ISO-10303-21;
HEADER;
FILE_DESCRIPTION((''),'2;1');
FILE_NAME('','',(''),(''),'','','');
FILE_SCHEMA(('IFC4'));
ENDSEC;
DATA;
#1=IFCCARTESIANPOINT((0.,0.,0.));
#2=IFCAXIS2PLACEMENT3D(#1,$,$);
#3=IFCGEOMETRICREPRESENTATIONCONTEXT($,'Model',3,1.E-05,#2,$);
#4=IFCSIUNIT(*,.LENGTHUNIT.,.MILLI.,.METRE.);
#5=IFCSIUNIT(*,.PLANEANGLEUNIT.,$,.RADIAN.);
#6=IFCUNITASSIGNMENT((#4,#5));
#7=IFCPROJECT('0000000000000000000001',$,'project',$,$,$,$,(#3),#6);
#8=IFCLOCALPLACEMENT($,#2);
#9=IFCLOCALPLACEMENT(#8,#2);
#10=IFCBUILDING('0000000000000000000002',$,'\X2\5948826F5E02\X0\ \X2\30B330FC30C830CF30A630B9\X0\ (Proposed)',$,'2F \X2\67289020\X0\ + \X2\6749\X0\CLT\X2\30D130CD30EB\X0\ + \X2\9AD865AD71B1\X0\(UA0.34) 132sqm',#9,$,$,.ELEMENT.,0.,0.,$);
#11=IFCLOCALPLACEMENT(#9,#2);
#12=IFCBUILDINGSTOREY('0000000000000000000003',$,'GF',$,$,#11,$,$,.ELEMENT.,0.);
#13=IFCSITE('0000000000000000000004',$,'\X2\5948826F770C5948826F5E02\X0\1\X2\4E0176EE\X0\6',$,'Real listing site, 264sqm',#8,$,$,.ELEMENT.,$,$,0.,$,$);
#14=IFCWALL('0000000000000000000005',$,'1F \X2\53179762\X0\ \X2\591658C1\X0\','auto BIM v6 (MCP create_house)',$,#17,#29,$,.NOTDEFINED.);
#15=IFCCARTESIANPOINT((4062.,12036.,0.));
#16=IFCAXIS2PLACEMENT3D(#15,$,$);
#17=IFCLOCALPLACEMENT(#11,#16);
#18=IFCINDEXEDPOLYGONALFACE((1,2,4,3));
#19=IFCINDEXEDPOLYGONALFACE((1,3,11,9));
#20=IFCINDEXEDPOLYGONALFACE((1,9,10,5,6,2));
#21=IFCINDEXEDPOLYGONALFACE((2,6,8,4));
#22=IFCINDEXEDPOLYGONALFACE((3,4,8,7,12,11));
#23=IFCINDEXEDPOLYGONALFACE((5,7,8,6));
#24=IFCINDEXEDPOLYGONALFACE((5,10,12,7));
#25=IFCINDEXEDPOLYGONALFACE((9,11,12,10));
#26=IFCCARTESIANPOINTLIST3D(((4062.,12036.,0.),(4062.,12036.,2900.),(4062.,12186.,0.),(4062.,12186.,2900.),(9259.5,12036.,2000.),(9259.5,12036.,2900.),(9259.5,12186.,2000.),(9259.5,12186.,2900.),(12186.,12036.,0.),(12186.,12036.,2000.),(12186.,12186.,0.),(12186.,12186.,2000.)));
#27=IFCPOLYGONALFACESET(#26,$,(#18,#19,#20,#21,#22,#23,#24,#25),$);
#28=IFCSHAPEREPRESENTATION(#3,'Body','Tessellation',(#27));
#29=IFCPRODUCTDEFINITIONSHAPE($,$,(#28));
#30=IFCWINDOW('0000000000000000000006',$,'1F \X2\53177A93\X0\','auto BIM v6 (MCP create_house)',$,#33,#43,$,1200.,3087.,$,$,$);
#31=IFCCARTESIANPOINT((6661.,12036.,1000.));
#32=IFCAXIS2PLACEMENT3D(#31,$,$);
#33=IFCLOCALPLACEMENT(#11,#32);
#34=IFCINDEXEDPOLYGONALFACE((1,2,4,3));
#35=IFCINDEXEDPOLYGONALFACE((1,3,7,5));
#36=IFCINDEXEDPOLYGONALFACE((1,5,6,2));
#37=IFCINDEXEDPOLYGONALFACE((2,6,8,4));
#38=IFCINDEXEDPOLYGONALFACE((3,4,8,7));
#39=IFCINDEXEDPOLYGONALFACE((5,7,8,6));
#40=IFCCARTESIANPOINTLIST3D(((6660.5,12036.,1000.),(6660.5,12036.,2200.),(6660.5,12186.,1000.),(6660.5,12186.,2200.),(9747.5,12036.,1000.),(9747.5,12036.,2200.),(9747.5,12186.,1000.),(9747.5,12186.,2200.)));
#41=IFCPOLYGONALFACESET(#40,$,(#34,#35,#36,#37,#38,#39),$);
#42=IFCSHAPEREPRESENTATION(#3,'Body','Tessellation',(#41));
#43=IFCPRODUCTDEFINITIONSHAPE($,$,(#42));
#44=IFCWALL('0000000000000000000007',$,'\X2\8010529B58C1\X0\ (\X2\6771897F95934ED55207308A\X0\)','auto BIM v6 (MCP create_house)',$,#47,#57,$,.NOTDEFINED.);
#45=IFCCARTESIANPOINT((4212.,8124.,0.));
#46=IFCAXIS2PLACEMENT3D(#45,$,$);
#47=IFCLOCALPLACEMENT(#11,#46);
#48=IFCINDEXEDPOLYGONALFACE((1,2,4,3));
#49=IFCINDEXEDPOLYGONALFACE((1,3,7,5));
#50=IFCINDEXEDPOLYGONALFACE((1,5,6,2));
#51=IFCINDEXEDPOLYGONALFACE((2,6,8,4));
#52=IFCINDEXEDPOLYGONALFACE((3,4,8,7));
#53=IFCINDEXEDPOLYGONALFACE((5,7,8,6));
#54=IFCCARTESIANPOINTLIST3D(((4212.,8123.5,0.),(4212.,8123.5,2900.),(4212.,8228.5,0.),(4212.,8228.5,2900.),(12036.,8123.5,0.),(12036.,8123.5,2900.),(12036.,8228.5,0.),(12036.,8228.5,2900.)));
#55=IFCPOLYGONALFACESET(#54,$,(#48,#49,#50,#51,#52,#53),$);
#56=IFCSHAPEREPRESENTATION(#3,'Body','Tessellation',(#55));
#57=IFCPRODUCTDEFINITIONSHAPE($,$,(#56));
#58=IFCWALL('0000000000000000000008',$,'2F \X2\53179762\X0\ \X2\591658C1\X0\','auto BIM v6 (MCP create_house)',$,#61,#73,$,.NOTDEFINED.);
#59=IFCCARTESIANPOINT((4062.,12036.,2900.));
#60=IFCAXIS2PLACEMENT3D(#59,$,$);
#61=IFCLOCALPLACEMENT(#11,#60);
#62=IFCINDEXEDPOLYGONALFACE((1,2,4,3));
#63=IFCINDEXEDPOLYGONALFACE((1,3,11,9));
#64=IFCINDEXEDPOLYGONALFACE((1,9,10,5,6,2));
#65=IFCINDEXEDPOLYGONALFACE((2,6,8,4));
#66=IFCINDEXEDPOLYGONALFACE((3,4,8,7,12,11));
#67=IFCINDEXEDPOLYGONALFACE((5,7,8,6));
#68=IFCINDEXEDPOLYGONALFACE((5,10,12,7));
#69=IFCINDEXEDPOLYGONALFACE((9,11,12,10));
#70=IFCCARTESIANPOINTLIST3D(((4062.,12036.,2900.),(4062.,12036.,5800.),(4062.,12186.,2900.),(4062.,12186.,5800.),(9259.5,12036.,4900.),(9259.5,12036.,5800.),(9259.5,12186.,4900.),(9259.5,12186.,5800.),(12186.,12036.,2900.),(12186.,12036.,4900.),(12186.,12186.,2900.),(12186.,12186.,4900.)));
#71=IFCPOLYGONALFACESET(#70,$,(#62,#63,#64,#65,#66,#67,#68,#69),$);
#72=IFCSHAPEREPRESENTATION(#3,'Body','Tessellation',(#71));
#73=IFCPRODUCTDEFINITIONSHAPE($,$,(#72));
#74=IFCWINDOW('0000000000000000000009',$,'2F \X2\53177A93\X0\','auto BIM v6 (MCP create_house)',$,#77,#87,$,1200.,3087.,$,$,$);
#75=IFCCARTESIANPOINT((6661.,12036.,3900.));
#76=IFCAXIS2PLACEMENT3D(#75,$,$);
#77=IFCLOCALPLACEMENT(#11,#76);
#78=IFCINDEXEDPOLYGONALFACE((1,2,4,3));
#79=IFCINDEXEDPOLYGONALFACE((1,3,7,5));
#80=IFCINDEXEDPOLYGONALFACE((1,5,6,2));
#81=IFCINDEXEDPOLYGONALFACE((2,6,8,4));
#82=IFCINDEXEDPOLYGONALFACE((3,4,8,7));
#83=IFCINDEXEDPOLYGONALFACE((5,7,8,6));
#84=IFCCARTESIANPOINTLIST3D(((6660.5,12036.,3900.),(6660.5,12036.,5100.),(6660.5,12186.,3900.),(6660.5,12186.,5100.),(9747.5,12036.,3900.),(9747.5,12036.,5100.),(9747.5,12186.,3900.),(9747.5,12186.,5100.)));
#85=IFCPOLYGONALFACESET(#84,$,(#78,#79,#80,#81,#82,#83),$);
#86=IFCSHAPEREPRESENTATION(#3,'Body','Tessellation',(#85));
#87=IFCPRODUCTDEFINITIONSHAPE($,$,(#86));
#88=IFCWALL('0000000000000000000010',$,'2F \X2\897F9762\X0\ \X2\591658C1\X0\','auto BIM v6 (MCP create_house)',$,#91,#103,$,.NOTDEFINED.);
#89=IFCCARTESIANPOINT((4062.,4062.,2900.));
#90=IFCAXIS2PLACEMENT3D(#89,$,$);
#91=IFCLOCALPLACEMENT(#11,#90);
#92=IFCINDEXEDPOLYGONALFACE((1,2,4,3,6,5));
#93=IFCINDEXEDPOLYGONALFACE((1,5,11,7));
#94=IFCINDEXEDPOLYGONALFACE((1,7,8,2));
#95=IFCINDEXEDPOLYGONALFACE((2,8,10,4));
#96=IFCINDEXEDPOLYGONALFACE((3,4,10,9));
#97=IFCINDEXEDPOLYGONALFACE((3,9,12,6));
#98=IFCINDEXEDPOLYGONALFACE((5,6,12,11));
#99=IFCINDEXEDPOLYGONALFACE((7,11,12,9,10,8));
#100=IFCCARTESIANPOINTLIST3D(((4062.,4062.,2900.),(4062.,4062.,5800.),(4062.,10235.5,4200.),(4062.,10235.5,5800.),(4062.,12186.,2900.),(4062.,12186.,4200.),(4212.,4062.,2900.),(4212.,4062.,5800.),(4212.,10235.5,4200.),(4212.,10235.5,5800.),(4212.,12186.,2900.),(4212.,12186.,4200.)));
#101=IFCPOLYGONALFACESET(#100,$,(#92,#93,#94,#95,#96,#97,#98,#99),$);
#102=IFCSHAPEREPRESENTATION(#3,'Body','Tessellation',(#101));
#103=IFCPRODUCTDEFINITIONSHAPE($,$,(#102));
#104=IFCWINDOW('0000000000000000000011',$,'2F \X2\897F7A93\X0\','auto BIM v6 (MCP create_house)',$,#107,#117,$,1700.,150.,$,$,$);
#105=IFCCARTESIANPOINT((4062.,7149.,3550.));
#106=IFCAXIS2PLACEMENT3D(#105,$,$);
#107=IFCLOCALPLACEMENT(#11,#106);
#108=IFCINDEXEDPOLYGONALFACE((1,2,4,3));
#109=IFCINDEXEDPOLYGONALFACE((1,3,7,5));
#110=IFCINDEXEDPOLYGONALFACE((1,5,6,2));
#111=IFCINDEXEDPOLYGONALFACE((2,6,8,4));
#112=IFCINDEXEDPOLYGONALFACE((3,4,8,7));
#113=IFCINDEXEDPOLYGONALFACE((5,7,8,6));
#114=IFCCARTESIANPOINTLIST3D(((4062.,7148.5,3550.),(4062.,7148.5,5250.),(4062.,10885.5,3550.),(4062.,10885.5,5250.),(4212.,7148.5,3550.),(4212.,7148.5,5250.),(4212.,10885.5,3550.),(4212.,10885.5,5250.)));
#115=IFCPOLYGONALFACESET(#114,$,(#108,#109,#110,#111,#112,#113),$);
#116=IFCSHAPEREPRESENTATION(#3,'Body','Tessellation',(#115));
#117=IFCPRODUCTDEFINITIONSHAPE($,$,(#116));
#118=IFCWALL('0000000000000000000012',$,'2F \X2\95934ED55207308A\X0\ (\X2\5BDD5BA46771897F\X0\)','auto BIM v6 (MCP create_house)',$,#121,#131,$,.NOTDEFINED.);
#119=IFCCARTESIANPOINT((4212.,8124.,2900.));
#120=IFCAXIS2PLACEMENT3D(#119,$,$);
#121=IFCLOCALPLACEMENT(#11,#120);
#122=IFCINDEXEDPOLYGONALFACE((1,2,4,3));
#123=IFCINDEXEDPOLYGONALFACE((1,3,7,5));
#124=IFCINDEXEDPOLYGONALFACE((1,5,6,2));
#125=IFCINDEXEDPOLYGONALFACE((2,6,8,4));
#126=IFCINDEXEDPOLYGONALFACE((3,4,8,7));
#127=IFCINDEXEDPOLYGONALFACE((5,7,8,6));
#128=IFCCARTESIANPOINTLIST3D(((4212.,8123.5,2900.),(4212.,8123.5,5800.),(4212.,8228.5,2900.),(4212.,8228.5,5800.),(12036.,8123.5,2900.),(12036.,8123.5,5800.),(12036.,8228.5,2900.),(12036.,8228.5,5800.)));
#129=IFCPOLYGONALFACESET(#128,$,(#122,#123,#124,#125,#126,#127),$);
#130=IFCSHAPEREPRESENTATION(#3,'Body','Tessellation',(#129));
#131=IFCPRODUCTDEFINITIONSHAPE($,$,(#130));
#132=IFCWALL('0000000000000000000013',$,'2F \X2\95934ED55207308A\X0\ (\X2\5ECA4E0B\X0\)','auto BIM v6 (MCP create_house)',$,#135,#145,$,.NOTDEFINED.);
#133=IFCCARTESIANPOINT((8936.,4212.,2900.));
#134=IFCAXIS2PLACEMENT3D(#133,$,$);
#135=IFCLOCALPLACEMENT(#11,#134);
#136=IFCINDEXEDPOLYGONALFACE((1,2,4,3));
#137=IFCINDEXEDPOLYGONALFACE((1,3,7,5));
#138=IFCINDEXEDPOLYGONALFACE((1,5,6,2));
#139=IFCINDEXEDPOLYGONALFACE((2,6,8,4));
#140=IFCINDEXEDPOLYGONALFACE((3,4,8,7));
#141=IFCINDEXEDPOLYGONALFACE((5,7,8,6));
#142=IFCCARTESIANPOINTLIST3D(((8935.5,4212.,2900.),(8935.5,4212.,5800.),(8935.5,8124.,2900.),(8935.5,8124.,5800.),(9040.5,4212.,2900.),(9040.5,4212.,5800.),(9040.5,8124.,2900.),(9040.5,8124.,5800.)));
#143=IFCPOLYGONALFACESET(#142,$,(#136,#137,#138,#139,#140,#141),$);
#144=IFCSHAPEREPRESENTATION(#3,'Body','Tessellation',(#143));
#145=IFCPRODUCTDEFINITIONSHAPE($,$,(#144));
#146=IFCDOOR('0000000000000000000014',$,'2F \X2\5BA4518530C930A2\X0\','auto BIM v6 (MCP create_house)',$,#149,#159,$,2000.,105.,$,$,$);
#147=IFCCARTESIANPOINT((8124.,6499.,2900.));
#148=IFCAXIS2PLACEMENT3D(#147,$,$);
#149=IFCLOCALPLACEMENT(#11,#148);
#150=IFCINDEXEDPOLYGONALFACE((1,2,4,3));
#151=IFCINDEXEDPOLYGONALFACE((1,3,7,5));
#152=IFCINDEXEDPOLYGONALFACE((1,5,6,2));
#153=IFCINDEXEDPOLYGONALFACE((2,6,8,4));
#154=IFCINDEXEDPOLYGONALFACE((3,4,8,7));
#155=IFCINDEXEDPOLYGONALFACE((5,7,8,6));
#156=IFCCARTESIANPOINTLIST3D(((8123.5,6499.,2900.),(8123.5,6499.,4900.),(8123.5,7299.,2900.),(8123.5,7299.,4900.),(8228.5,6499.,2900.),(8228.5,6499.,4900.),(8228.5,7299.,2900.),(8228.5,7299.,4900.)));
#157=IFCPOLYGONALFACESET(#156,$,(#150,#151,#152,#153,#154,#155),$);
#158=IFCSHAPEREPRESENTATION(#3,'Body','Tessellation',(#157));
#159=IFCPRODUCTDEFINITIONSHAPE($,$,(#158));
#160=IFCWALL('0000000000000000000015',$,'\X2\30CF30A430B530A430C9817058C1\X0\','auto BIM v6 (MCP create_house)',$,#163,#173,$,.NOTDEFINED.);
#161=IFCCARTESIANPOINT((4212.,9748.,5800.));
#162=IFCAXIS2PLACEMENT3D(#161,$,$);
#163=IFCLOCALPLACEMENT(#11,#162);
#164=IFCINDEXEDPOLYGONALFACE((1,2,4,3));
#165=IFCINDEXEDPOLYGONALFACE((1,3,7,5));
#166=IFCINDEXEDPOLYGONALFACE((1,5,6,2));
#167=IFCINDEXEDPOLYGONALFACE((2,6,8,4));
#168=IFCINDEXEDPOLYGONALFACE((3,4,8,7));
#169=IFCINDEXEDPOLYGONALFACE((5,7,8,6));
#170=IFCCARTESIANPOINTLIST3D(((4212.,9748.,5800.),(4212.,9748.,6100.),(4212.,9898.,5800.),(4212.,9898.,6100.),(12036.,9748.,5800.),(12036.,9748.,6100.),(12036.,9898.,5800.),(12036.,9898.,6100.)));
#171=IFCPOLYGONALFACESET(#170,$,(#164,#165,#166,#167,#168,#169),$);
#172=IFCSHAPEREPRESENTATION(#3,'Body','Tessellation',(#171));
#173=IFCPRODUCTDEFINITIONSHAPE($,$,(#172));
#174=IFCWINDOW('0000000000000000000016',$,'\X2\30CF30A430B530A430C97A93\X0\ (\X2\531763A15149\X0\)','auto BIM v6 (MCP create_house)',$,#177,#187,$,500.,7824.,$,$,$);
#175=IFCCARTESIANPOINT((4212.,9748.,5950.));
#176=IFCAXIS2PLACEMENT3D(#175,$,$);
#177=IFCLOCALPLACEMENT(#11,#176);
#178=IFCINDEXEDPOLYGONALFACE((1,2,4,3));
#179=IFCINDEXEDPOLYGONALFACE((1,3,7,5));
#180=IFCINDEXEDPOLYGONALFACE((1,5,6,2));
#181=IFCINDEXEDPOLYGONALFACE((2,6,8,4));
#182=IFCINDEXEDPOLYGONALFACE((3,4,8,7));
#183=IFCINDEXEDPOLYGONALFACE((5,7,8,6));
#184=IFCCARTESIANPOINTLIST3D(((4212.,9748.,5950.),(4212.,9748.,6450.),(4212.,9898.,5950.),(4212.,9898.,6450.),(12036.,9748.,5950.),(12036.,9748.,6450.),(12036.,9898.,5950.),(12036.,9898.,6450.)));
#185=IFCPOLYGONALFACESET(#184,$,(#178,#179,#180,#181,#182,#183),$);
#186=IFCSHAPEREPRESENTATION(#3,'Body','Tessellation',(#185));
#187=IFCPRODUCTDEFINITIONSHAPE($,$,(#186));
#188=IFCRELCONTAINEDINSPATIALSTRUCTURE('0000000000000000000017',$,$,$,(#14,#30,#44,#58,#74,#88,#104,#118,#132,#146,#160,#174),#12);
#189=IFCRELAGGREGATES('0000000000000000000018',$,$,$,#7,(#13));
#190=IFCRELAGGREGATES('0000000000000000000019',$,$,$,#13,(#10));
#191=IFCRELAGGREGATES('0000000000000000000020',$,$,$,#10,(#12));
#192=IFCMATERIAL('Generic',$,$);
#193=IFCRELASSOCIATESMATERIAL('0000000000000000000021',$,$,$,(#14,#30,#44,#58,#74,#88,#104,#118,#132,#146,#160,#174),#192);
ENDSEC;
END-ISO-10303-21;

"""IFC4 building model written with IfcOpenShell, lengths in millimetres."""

from ifc_helpers import new_model, si_unit, frame, frame_2d, origin, place, context, project, spatial, rectangle, extrude, material, element, fill, save


model = new_model("IFC4")

# Units and contexts
model_context = context("Model", 3, precision=1e-05, world=origin())
ifc_project = project(units=[si_unit("LENGTHUNIT", "METRE", prefix="MILLI"), si_unit("PLANEANGLEUNIT", "RADIAN")], contexts=[model_context])

# Site, building, storey
site_placement = place(None, origin())
site = spatial("IfcSite", under=ifc_project, at=site_placement, Name="奈良県奈良市1丁目6", ObjectType="Real listing site, 264sqm", CompositionType="ELEMENT", RefElevation=0.0)
building_placement = place(site_placement, origin())
building = spatial("IfcBuilding", under=site, at=building_placement, Name="奈良市 コートハウス (Proposed)", ObjectType="2F 木造 + 杉CLTパネル + 高断熱(UA0.34) 132sqm", CompositionType="ELEMENT", ElevationOfRefHeight=0.0, ElevationOfTerrain=0.0)
storey_placement = place(building_placement, origin())
storey = spatial("IfcBuildingStorey", under=building, at=storey_placement, Name="GF", CompositionType="ELEMENT", Elevation=0.0)

# Wall, opening, window
ifc_material = material(Name="Generic")
wall_1_placement = place(storey_placement, frame((4062.0, 12036.0, 0.0)))
wall_1 = element("IfcWall", 1, at=wall_1_placement, inside=storey, material=ifc_material, Name="1F 北面 外壁", Description="auto BIM v6 (MCP create_house)", PredefinedType="NOTDEFINED", context=model_context, shape_type="SweptSolid", body=[
    extrude(rectangle(XDim=8124.0, YDim=150.0, at=frame_2d((4062.0, 75.0))), frame((4062.0, 12036.0, 0.0)), (0.0, 0.0, 1.0), 2900.0),
])
opening_1_placement = place(storey_placement, frame((6661.0, 12036.0, 1000.0)))
opening_1 = element("IfcOpeningElement", 2, at=opening_1_placement, cuts=wall_1, PredefinedType="NOTDEFINED", context=model_context, shape_type="SweptSolid", body=[
    extrude(rectangle(XDim=3087.0, YDim=150.0, at=frame_2d((1543.0, 75.0))), frame((6661.0, 12036.0, 1000.0)), (0.0, 0.0, 1.0), 1200.0),
])
window_1_placement = place(storey_placement, frame((6661.0, 12036.0, 1000.0)))
window_1 = element("IfcWindow", 3, at=window_1_placement, inside=storey, material=ifc_material, Name="1F 北窓", Description="auto BIM v6 (MCP create_house)", OverallHeight=1200.0, OverallWidth=3087.0, context=model_context, shape_type="SweptSolid", body=[
    extrude(rectangle(XDim=3087.0, YDim=150.0, at=frame_2d((1543.0, 75.0))), frame((6661.0, 12036.0, 1000.0)), (0.0, 0.0, 1.0), 1200.0),
])
fill(opening_1, window_1)

# Wall
wall_2_placement = place(storey_placement, frame((4212.0, 8124.0, 0.0)))
element("IfcWall", 4, at=wall_2_placement, inside=storey, material=ifc_material, Name="耐力壁 (東西間仕切り)", Description="auto BIM v6 (MCP create_house)", PredefinedType="NOTDEFINED", context=model_context, shape_type="SweptSolid", body=[
    extrude(rectangle(XDim=7824.0, YDim=105.0, at=frame_2d((3912.0, 52.0))), frame((4212.0, 8124.0, 0.0)), (0.0, 0.0, 1.0), 2900.0),
])

# Walls, openings, windows
wall_3_placement = place(storey_placement, frame((4062.0, 12036.0, 2900.0)))
wall_3 = element("IfcWall", 5, at=wall_3_placement, inside=storey, material=ifc_material, Name="2F 北面 外壁", Description="auto BIM v6 (MCP create_house)", PredefinedType="NOTDEFINED", context=model_context, shape_type="SweptSolid", body=[
    extrude(rectangle(XDim=8124.0, YDim=150.0, at=frame_2d((4062.0, 75.0))), frame((4062.0, 12036.0, 2900.0)), (0.0, 0.0, 1.0), 2900.0),
])
opening_2_placement = place(storey_placement, frame((6661.0, 12036.0, 3900.0)))
opening_2 = element("IfcOpeningElement", 6, at=opening_2_placement, cuts=wall_3, PredefinedType="NOTDEFINED", context=model_context, shape_type="SweptSolid", body=[
    extrude(rectangle(XDim=3087.0, YDim=150.0, at=frame_2d((1543.0, 75.0))), frame((6661.0, 12036.0, 3900.0)), (0.0, 0.0, 1.0), 1200.0),
])
window_2_placement = place(storey_placement, frame((6661.0, 12036.0, 3900.0)))
window_2 = element("IfcWindow", 7, at=window_2_placement, inside=storey, material=ifc_material, Name="2F 北窓", Description="auto BIM v6 (MCP create_house)", OverallHeight=1200.0, OverallWidth=3087.0, context=model_context, shape_type="SweptSolid", body=[
    extrude(rectangle(XDim=3087.0, YDim=150.0, at=frame_2d((1543.0, 75.0))), frame((6661.0, 12036.0, 3900.0)), (0.0, 0.0, 1.0), 1200.0),
])
fill(opening_2, window_2)
wall_4_placement = place(storey_placement, frame((4062.0, 4062.0, 2900.0)))
wall_4 = element("IfcWall", 8, at=wall_4_placement, inside=storey, material=ifc_material, Name="2F 西面 外壁", Description="auto BIM v6 (MCP create_house)", PredefinedType="NOTDEFINED", context=model_context, shape_type="SweptSolid", body=[
    extrude(rectangle(XDim=150.0, YDim=8124.0, at=frame_2d((75.0, 4062.0))), frame((4062.0, 4062.0, 2900.0)), (0.0, 0.0, 1.0), 2900.0),
])
opening_3_placement = place(storey_placement, frame((4062.0, 7149.0, 3550.0)))
opening_3 = element("IfcOpeningElement", 9, at=opening_3_placement, cuts=wall_4, PredefinedType="NOTDEFINED", context=model_context, shape_type="SweptSolid", body=[
    extrude(rectangle(XDim=150.0, YDim=3737.0, at=frame_2d((75.0, 1868.0))), frame((4062.0, 7149.0, 3550.0)), (0.0, 0.0, 1.0), 1700.0),
])
window_3_placement = place(storey_placement, frame((4062.0, 7149.0, 3550.0)))
window_3 = element("IfcWindow", 10, at=window_3_placement, inside=storey, material=ifc_material, Name="2F 西窓", Description="auto BIM v6 (MCP create_house)", OverallHeight=1700.0, OverallWidth=150.0, context=model_context, shape_type="SweptSolid", body=[
    extrude(rectangle(XDim=150.0, YDim=3737.0, at=frame_2d((75.0, 1868.0))), frame((4062.0, 7149.0, 3550.0)), (0.0, 0.0, 1.0), 1700.0),
])
fill(opening_3, window_3)

# Walls
wall_5_placement = place(storey_placement, frame((4212.0, 8124.0, 2900.0)))
element("IfcWall", 11, at=wall_5_placement, inside=storey, material=ifc_material, Name="2F 間仕切り (寝室東西)", Description="auto BIM v6 (MCP create_house)", PredefinedType="NOTDEFINED", context=model_context, shape_type="SweptSolid", body=[
    extrude(rectangle(XDim=7824.0, YDim=105.0, at=frame_2d((3912.0, 52.0))), frame((4212.0, 8124.0, 2900.0)), (0.0, 0.0, 1.0), 2900.0),
])
wall_6_placement = place(storey_placement, frame((8936.0, 4212.0, 2900.0)))
element("IfcWall", 12, at=wall_6_placement, inside=storey, material=ifc_material, Name="2F 間仕切り (廊下)", Description="auto BIM v6 (MCP create_house)", PredefinedType="NOTDEFINED", context=model_context, shape_type="SweptSolid", body=[
    extrude(rectangle(XDim=105.0, YDim=3912.0, at=frame_2d((52.0, 1956.0))), frame((8936.0, 4212.0, 2900.0)), (0.0, 0.0, 1.0), 2900.0),
])

# Door
door_placement = place(storey_placement, frame((8124.0, 6499.0, 2900.0)))
element("IfcDoor", 13, at=door_placement, inside=storey, material=ifc_material, Name="2F 室内ドア", Description="auto BIM v6 (MCP create_house)", OverallHeight=2000.0, OverallWidth=105.0, context=model_context, shape_type="SweptSolid", body=[
    extrude(rectangle(XDim=105.0, YDim=800.0, at=frame_2d((52.0, 400.0))), frame((8124.0, 6499.0, 2900.0)), (0.0, 0.0, 1.0), 2000.0),
])

# Wall, opening, window
wall_7_placement = place(storey_placement, frame((4212.0, 9748.0, 5800.0)))
wall_7 = element("IfcWall", 14, at=wall_7_placement, inside=storey, material=ifc_material, Name="ハイサイド腰壁", Description="auto BIM v6 (MCP create_house)", PredefinedType="NOTDEFINED", context=model_context, shape_type="SweptSolid", body=[
    extrude(rectangle(XDim=7824.0, YDim=150.0, at=frame_2d((3912.0, 75.0))), frame((4212.0, 9748.0, 5800.0)), (0.0, 0.0, 1.0), 700.0),
])
opening_4_placement = place(storey_placement, frame((4212.0, 9748.0, 5950.0)))
opening_4 = element("IfcOpeningElement", 15, at=opening_4_placement, cuts=wall_7, PredefinedType="NOTDEFINED", context=model_context, shape_type="SweptSolid", body=[
    extrude(rectangle(XDim=7824.0, YDim=150.0, at=frame_2d((3912.0, 75.0))), frame((4212.0, 9748.0, 5950.0)), (0.0, 0.0, 1.0), 500.0),
])
window_4_placement = place(storey_placement, frame((4212.0, 9748.0, 5950.0)))
window_4 = element("IfcWindow", 16, at=window_4_placement, inside=storey, material=ifc_material, Name="ハイサイド窓 (北採光)", Description="auto BIM v6 (MCP create_house)", OverallHeight=500.0, OverallWidth=7824.0, context=model_context, shape_type="SweptSolid", body=[
    extrude(rectangle(XDim=7824.0, YDim=150.0, at=frame_2d((3912.0, 75.0))), frame((4212.0, 9748.0, 5950.0)), (0.0, 0.0, 1.0), 500.0),
])
fill(opening_4, window_4)

save(model, "model.ifc")
